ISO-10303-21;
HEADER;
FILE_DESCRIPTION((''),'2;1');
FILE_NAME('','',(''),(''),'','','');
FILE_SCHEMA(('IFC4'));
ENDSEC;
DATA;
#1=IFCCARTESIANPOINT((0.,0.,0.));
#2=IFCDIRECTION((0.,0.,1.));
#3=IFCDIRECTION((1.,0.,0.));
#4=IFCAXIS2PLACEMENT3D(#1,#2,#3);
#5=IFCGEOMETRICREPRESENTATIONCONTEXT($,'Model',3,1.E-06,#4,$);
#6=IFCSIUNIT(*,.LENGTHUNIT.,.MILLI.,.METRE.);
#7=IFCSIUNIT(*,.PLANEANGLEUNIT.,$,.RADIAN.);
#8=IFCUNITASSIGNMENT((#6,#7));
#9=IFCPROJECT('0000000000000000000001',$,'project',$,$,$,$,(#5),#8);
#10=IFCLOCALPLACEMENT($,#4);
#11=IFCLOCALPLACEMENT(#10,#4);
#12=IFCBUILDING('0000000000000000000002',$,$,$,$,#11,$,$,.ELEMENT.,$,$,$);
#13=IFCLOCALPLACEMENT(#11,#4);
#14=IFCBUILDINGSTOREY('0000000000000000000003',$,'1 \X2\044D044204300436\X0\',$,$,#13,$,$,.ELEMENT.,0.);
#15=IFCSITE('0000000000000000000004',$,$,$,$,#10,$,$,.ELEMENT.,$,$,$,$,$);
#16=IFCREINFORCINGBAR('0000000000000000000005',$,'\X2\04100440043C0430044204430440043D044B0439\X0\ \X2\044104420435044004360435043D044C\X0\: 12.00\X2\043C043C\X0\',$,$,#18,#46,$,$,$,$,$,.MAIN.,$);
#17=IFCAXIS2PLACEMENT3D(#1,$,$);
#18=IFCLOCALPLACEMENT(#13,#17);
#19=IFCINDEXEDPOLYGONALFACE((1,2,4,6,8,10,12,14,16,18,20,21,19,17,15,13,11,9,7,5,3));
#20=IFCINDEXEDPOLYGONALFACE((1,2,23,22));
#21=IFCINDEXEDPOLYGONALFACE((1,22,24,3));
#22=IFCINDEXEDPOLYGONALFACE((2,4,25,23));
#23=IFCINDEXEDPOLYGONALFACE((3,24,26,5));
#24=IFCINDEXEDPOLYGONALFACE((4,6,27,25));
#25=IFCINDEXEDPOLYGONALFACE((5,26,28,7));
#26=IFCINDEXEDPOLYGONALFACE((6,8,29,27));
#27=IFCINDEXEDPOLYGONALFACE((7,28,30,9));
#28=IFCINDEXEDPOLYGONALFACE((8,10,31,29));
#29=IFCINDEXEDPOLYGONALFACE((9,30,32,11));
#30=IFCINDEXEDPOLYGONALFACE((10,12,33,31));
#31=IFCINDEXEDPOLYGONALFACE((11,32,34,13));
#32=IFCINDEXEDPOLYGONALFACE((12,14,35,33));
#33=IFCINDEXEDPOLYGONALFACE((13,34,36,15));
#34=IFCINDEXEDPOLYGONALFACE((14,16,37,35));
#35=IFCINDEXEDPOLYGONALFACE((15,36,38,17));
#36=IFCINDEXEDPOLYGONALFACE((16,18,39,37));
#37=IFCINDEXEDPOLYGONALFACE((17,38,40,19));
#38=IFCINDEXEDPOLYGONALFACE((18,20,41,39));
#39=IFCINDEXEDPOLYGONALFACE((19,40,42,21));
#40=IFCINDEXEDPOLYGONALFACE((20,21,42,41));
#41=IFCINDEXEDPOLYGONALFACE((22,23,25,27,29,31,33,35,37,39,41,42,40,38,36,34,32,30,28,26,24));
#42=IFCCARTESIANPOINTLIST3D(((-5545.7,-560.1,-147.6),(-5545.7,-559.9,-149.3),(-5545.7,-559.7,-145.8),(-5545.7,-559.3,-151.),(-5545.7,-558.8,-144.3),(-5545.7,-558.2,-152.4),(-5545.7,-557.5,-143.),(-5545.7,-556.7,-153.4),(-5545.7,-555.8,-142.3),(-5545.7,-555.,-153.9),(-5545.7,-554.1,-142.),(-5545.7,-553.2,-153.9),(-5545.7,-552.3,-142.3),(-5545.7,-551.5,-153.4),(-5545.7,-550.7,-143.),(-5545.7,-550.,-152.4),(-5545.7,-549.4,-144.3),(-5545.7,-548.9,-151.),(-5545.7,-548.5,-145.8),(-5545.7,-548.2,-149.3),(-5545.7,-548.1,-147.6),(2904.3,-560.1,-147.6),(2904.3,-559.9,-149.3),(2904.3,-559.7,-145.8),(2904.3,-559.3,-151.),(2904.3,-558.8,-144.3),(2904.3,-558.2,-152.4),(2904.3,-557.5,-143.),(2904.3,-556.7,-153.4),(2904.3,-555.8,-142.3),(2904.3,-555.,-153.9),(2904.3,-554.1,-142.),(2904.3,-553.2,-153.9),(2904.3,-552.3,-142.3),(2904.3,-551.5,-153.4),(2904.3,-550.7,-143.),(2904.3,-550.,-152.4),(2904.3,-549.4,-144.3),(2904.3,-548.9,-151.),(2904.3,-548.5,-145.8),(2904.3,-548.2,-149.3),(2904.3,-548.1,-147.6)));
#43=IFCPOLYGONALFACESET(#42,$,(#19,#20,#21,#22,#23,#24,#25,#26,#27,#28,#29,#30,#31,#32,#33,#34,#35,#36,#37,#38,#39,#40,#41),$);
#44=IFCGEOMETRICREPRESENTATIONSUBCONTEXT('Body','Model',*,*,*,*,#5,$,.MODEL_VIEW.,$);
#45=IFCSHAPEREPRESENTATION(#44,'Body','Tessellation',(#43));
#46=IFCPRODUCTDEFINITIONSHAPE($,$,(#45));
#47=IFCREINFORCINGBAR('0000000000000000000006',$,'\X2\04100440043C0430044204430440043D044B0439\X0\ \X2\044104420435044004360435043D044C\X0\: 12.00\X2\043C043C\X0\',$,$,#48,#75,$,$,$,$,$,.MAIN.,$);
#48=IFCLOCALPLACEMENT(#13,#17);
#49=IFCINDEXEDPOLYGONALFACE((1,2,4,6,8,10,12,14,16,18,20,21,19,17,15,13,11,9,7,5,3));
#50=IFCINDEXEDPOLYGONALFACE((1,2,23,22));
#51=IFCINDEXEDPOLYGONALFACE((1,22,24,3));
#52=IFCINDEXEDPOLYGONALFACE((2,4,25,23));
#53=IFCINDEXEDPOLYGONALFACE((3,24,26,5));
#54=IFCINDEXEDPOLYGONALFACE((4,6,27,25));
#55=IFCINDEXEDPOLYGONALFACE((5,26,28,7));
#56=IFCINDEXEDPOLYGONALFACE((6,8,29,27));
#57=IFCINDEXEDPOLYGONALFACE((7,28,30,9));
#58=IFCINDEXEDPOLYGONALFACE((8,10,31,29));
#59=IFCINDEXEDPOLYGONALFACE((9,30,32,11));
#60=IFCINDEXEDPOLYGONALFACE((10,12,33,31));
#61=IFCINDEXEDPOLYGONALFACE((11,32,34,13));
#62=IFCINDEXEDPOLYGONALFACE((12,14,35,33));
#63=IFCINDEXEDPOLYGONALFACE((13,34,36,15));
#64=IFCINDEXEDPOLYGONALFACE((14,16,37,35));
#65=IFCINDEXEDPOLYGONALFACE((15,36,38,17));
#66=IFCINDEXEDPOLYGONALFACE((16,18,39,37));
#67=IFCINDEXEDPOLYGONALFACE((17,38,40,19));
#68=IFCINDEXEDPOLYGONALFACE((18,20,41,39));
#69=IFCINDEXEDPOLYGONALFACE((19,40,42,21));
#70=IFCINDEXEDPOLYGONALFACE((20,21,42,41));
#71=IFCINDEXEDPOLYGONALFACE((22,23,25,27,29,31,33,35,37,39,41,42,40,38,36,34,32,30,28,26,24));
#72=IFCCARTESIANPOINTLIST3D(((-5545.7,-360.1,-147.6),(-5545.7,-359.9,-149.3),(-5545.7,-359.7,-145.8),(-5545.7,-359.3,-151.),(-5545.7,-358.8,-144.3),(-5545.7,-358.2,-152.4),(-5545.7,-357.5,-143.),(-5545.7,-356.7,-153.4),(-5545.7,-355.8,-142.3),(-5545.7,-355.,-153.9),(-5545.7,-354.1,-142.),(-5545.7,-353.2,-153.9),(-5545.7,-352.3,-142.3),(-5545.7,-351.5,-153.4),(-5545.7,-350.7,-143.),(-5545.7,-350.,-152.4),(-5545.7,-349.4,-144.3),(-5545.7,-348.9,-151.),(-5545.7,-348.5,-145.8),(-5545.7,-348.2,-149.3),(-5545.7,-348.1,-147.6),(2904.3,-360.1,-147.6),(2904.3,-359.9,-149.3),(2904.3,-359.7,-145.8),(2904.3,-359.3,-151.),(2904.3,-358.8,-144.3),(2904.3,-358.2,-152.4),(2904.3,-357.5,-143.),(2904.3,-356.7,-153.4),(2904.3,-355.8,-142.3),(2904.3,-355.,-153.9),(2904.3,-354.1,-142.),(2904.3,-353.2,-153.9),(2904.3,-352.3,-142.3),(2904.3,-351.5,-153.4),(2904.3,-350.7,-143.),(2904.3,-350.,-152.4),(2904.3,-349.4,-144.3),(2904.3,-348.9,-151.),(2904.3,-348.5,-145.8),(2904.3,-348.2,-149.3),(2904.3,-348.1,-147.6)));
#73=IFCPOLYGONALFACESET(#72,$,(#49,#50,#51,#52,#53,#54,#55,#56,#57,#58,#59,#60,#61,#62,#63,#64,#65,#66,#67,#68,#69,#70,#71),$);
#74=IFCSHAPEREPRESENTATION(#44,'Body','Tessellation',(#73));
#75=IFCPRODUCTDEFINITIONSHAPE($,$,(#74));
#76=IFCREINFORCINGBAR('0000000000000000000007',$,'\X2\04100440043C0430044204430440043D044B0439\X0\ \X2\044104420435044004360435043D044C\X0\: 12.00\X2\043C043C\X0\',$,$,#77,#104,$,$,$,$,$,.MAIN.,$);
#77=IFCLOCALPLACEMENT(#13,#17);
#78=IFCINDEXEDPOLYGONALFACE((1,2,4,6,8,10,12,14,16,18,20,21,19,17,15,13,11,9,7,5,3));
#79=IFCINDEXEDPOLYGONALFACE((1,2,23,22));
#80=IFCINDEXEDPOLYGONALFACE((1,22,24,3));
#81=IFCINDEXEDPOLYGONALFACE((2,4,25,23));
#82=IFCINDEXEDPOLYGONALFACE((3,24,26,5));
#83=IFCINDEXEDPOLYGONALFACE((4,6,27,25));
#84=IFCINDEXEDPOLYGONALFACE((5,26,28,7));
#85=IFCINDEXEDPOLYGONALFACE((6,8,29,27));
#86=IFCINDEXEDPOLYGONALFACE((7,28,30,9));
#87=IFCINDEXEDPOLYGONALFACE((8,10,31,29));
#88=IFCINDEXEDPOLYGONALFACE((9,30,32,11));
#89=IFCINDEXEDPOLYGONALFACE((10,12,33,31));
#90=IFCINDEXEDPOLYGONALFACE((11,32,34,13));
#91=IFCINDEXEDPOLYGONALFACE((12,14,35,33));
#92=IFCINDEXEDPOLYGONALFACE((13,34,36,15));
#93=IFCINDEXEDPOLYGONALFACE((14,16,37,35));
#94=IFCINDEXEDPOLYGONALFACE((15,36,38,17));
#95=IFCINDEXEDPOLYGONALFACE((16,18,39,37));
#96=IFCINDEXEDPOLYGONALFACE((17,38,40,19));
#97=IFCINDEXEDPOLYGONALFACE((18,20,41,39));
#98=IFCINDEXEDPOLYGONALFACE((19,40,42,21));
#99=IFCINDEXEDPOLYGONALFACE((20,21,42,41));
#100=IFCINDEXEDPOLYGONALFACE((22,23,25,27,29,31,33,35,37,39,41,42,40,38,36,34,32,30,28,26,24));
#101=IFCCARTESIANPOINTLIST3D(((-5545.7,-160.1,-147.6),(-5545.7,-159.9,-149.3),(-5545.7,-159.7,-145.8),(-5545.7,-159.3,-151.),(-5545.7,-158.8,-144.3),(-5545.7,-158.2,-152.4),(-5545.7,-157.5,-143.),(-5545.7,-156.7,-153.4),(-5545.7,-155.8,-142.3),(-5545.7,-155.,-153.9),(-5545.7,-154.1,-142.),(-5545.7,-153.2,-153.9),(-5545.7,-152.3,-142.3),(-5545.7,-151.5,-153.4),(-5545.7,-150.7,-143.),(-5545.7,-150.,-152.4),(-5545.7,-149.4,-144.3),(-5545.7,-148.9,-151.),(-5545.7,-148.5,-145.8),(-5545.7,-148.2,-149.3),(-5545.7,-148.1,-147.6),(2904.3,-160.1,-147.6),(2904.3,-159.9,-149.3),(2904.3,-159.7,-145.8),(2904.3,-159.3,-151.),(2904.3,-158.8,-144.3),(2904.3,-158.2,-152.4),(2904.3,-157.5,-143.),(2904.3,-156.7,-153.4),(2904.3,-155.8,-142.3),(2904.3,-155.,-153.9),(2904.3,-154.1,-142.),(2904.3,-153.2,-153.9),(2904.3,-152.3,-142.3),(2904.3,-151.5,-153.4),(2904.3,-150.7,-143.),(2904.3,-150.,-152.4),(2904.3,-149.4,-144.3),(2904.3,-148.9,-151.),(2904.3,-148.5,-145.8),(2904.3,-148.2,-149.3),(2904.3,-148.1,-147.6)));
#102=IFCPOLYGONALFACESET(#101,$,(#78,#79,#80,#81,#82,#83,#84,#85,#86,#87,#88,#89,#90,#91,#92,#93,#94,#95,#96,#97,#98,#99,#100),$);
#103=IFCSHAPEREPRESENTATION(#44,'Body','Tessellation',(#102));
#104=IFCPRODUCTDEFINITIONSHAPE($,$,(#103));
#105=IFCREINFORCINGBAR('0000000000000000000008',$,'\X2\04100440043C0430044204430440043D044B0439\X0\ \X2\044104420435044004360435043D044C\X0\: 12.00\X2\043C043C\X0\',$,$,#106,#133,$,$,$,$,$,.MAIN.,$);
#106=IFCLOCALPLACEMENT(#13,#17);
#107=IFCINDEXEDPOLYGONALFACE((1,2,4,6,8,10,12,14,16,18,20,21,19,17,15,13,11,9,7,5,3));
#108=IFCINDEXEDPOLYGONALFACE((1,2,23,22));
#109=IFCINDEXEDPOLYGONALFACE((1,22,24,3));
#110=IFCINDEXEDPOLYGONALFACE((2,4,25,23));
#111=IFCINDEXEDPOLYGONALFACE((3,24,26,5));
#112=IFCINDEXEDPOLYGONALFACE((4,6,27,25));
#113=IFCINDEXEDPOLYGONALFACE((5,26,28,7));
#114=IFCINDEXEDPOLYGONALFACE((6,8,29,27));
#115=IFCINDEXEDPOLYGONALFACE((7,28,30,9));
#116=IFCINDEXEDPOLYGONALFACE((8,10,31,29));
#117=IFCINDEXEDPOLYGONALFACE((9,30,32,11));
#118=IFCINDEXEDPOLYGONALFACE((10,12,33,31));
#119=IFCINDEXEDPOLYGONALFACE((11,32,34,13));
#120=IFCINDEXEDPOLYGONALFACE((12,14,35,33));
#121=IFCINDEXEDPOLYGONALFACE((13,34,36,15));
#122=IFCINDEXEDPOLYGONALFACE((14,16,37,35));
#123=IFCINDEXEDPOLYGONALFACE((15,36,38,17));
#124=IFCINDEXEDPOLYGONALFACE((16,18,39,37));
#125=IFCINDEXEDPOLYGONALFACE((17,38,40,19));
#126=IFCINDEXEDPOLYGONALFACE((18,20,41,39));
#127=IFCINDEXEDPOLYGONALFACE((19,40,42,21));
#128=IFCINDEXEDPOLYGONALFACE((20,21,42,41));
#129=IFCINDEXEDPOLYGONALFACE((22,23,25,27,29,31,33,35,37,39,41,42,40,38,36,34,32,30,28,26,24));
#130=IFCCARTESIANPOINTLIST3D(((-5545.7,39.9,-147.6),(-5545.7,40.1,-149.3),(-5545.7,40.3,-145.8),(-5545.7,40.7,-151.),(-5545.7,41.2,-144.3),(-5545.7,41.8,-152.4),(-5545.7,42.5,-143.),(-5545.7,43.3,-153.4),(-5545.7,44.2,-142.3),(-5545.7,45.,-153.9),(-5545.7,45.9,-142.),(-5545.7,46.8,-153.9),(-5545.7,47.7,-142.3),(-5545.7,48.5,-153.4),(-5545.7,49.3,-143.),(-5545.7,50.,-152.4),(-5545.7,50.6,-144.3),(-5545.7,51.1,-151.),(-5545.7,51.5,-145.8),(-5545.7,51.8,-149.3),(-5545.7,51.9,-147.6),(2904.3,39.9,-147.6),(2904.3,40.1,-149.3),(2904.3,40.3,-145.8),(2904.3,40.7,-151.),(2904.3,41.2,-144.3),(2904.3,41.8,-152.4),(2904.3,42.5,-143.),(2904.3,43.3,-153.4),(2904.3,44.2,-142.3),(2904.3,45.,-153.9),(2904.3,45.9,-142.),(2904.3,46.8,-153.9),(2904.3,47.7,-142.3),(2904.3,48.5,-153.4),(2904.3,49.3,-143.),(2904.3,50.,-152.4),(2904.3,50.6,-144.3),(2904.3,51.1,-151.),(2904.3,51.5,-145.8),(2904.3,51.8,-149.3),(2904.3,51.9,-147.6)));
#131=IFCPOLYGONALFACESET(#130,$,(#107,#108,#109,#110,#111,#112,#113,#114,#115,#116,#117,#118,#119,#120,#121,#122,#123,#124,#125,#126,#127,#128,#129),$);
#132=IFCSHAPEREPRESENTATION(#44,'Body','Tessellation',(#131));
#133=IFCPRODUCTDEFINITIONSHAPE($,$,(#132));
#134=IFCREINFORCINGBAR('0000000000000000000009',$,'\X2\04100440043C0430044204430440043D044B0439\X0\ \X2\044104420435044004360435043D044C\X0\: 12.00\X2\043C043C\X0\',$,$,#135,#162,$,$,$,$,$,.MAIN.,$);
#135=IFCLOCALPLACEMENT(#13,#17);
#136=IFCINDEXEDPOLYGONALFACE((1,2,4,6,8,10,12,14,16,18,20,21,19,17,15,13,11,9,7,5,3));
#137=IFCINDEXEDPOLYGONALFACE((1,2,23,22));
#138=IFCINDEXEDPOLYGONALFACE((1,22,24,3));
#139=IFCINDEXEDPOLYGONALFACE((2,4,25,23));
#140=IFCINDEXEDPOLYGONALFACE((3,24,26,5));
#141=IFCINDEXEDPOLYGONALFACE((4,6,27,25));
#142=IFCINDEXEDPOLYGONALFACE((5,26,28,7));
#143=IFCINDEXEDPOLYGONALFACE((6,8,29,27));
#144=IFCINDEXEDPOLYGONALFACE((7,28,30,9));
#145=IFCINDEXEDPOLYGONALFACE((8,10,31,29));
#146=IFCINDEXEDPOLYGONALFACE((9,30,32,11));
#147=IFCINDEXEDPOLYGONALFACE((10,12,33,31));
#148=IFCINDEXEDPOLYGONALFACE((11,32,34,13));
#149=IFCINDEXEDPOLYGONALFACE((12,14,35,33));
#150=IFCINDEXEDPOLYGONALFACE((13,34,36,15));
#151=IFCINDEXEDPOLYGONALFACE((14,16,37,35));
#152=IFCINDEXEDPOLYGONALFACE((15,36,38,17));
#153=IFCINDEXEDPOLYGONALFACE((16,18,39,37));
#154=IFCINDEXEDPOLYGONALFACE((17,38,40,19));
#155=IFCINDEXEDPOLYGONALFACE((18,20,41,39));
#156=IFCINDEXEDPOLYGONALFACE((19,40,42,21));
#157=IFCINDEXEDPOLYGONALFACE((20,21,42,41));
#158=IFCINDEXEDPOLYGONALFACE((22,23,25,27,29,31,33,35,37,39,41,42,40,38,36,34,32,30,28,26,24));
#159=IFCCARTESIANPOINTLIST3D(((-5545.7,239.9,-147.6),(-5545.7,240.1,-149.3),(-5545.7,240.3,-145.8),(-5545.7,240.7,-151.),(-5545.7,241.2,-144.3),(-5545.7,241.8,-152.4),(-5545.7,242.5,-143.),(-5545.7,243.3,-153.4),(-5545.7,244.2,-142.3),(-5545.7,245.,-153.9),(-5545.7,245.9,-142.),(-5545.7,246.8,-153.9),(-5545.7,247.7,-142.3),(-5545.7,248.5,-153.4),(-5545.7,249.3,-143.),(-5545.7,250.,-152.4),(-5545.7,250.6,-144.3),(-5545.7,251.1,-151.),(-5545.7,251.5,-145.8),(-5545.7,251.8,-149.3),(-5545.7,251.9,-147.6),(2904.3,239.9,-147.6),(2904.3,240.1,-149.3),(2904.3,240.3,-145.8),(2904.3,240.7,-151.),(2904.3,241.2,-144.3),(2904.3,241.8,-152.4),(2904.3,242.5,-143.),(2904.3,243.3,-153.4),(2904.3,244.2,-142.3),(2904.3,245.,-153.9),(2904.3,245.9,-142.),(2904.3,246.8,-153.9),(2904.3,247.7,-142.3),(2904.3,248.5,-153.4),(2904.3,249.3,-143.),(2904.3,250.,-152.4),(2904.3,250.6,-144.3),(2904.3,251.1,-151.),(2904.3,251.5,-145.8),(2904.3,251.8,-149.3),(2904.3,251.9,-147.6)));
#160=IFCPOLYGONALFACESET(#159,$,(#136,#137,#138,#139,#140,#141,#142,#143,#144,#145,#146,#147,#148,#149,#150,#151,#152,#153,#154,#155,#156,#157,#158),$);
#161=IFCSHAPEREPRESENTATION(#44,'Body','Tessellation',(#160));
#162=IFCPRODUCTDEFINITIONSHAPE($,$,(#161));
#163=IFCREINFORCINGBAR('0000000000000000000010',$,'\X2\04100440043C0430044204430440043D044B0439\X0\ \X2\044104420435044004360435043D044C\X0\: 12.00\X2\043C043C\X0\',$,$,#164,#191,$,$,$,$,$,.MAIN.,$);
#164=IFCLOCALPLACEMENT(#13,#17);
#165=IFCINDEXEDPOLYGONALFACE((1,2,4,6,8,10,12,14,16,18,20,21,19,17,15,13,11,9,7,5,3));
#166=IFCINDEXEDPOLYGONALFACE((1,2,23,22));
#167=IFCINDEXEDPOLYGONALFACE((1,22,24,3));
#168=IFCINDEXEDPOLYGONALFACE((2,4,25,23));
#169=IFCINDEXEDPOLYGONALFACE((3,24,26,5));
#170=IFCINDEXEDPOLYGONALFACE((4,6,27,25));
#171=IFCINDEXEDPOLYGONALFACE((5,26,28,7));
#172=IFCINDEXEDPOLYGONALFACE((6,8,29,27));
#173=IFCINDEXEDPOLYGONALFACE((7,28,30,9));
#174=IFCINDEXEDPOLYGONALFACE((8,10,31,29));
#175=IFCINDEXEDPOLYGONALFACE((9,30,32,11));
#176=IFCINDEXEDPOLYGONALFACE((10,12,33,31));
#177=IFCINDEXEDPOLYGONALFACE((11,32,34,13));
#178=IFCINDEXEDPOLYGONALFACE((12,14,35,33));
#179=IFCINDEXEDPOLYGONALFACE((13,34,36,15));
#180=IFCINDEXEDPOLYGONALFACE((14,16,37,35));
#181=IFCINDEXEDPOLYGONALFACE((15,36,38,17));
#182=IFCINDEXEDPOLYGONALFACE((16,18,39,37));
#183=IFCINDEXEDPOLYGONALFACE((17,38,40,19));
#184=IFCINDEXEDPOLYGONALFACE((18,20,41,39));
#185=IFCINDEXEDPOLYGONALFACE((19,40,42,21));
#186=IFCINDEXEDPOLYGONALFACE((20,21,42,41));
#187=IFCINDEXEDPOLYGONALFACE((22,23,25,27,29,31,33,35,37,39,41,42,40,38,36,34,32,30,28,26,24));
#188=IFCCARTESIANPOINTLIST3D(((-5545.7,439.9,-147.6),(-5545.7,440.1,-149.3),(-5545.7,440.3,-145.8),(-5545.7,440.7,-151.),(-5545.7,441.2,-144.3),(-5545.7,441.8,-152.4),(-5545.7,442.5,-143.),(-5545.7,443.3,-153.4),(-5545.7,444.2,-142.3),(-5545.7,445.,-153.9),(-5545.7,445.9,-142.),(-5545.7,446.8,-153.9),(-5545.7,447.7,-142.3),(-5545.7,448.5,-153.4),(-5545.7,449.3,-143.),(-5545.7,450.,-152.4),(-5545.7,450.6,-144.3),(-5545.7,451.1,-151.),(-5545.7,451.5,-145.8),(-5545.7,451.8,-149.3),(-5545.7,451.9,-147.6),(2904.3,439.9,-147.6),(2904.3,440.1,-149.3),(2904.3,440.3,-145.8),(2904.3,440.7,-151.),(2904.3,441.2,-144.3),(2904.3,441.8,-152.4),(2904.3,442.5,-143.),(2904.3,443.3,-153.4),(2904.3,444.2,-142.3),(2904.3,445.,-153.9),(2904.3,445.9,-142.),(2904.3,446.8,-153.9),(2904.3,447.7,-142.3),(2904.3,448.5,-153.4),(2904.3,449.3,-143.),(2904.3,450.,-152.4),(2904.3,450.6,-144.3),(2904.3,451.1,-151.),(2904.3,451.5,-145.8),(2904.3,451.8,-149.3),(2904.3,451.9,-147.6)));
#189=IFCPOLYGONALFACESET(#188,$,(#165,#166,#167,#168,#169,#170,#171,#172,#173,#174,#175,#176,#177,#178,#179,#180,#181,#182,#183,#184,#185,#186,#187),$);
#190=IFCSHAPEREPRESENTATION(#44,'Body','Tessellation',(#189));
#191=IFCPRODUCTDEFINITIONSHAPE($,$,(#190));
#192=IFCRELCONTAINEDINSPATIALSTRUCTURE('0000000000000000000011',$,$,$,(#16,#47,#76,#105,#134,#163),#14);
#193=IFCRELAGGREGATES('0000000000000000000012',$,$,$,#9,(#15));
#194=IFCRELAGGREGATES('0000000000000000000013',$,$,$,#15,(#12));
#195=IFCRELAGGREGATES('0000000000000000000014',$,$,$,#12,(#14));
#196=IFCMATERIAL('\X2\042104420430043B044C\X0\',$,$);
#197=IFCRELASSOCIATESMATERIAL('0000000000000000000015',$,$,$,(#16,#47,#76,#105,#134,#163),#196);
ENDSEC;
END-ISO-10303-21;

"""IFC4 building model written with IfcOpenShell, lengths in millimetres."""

from ifc_helpers import new_model, entity, si_unit, origin_with_axes, place, context, subcontext, project, spatial, source, transform, mapped, material, element, save


model = new_model("IFC4")

# Units and contexts
model_context = context("Model", 3, precision=1e-06, world=origin_with_axes())
body_context = subcontext(model_context, "Body", "Model", "MODEL_VIEW")
ifc_project = project(units=[si_unit("LENGTHUNIT", "METRE", prefix="MILLI"), si_unit("PLANEANGLEUNIT", "RADIAN")], contexts=[model_context])

# Site, building, storey
site_placement = place(None, origin_with_axes())
site = spatial("IfcSite", under=ifc_project, at=site_placement, CompositionType="ELEMENT")
building_placement = place(site_placement, origin_with_axes())
building = spatial("IfcBuilding", under=site, at=building_placement, CompositionType="ELEMENT")
storey_placement = place(building_placement, origin_with_axes())
storey = spatial("IfcBuildingStorey", under=building, at=storey_placement, Name="1 этаж", CompositionType="ELEMENT", Elevation=0.0)

# Reinforcing bars
ifc_material = material(Name="Сталь")
shared_shape = source(origin_with_axes(), body_context, "Body", "AdvancedSweptSolid", [
    entity("IfcSweptDiskSolid", entity("IfcIndexedPolyCurve", entity("IfcCartesianPointList3D", [[0.0, 0.0, 0.0], [8450.0, 0.0, 0.0]]), [entity("IfcLineIndex", [1, 2])]), 6.0),
])
reinforcing_bar_1_placement = place(storey_placement, origin_with_axes())
element("IfcReinforcingBar", 1, at=reinforcing_bar_1_placement, inside=storey, material=ifc_material, Name="Арматурный стержень: 12.00мм", PredefinedType="MAIN", context=body_context, shape_type="MappedRepresentation", body=[
    mapped(shared_shape, transform((-5545.7, -554.1, -148.0), x_axis=(1.0, 0.0, 0.0), y_axis=(0.0, 1.0, 0.0), z_axis=(0.0, 0.0, 1.0), scale=1.0)),
])
reinforcing_bar_2_placement = place(storey_placement, origin_with_axes())
element("IfcReinforcingBar", 2, at=reinforcing_bar_2_placement, inside=storey, material=ifc_material, Name="Арматурный стержень: 12.00мм", PredefinedType="MAIN", context=body_context, shape_type="MappedRepresentation", body=[
    mapped(shared_shape, transform((-5545.7, -354.1, -148.0), x_axis=(1.0, 0.0, 0.0), y_axis=(0.0, 1.0, 0.0), z_axis=(0.0, 0.0, 1.0), scale=1.0)),
])
reinforcing_bar_3_placement = place(storey_placement, origin_with_axes())
element("IfcReinforcingBar", 3, at=reinforcing_bar_3_placement, inside=storey, material=ifc_material, Name="Арматурный стержень: 12.00мм", PredefinedType="MAIN", context=body_context, shape_type="MappedRepresentation", body=[
    mapped(shared_shape, transform((-5545.7, -154.1, -148.0), x_axis=(1.0, 0.0, 0.0), y_axis=(0.0, 1.0, 0.0), z_axis=(0.0, 0.0, 1.0), scale=1.0)),
])
reinforcing_bar_4_placement = place(storey_placement, origin_with_axes())
element("IfcReinforcingBar", 4, at=reinforcing_bar_4_placement, inside=storey, material=ifc_material, Name="Арматурный стержень: 12.00мм", PredefinedType="MAIN", context=body_context, shape_type="MappedRepresentation", body=[
    mapped(shared_shape, transform((-5545.7, 45.9, -148.0), x_axis=(1.0, 0.0, 0.0), y_axis=(0.0, 1.0, 0.0), z_axis=(0.0, 0.0, 1.0), scale=1.0)),
])
reinforcing_bar_5_placement = place(storey_placement, origin_with_axes())
element("IfcReinforcingBar", 5, at=reinforcing_bar_5_placement, inside=storey, material=ifc_material, Name="Арматурный стержень: 12.00мм", PredefinedType="MAIN", context=body_context, shape_type="MappedRepresentation", body=[
    mapped(shared_shape, transform((-5545.7, 245.9, -148.0), x_axis=(1.0, 0.0, 0.0), y_axis=(0.0, 1.0, 0.0), z_axis=(0.0, 0.0, 1.0), scale=1.0)),
])
reinforcing_bar_6_placement = place(storey_placement, origin_with_axes())
element("IfcReinforcingBar", 6, at=reinforcing_bar_6_placement, inside=storey, material=ifc_material, Name="Арматурный стержень: 12.00мм", PredefinedType="MAIN", context=body_context, shape_type="MappedRepresentation", body=[
    mapped(shared_shape, transform((-5545.7, 445.9, -148.0), x_axis=(1.0, 0.0, 0.0), y_axis=(0.0, 1.0, 0.0), z_axis=(0.0, 0.0, 1.0), scale=1.0)),
])

save(model, "model.ifc")
